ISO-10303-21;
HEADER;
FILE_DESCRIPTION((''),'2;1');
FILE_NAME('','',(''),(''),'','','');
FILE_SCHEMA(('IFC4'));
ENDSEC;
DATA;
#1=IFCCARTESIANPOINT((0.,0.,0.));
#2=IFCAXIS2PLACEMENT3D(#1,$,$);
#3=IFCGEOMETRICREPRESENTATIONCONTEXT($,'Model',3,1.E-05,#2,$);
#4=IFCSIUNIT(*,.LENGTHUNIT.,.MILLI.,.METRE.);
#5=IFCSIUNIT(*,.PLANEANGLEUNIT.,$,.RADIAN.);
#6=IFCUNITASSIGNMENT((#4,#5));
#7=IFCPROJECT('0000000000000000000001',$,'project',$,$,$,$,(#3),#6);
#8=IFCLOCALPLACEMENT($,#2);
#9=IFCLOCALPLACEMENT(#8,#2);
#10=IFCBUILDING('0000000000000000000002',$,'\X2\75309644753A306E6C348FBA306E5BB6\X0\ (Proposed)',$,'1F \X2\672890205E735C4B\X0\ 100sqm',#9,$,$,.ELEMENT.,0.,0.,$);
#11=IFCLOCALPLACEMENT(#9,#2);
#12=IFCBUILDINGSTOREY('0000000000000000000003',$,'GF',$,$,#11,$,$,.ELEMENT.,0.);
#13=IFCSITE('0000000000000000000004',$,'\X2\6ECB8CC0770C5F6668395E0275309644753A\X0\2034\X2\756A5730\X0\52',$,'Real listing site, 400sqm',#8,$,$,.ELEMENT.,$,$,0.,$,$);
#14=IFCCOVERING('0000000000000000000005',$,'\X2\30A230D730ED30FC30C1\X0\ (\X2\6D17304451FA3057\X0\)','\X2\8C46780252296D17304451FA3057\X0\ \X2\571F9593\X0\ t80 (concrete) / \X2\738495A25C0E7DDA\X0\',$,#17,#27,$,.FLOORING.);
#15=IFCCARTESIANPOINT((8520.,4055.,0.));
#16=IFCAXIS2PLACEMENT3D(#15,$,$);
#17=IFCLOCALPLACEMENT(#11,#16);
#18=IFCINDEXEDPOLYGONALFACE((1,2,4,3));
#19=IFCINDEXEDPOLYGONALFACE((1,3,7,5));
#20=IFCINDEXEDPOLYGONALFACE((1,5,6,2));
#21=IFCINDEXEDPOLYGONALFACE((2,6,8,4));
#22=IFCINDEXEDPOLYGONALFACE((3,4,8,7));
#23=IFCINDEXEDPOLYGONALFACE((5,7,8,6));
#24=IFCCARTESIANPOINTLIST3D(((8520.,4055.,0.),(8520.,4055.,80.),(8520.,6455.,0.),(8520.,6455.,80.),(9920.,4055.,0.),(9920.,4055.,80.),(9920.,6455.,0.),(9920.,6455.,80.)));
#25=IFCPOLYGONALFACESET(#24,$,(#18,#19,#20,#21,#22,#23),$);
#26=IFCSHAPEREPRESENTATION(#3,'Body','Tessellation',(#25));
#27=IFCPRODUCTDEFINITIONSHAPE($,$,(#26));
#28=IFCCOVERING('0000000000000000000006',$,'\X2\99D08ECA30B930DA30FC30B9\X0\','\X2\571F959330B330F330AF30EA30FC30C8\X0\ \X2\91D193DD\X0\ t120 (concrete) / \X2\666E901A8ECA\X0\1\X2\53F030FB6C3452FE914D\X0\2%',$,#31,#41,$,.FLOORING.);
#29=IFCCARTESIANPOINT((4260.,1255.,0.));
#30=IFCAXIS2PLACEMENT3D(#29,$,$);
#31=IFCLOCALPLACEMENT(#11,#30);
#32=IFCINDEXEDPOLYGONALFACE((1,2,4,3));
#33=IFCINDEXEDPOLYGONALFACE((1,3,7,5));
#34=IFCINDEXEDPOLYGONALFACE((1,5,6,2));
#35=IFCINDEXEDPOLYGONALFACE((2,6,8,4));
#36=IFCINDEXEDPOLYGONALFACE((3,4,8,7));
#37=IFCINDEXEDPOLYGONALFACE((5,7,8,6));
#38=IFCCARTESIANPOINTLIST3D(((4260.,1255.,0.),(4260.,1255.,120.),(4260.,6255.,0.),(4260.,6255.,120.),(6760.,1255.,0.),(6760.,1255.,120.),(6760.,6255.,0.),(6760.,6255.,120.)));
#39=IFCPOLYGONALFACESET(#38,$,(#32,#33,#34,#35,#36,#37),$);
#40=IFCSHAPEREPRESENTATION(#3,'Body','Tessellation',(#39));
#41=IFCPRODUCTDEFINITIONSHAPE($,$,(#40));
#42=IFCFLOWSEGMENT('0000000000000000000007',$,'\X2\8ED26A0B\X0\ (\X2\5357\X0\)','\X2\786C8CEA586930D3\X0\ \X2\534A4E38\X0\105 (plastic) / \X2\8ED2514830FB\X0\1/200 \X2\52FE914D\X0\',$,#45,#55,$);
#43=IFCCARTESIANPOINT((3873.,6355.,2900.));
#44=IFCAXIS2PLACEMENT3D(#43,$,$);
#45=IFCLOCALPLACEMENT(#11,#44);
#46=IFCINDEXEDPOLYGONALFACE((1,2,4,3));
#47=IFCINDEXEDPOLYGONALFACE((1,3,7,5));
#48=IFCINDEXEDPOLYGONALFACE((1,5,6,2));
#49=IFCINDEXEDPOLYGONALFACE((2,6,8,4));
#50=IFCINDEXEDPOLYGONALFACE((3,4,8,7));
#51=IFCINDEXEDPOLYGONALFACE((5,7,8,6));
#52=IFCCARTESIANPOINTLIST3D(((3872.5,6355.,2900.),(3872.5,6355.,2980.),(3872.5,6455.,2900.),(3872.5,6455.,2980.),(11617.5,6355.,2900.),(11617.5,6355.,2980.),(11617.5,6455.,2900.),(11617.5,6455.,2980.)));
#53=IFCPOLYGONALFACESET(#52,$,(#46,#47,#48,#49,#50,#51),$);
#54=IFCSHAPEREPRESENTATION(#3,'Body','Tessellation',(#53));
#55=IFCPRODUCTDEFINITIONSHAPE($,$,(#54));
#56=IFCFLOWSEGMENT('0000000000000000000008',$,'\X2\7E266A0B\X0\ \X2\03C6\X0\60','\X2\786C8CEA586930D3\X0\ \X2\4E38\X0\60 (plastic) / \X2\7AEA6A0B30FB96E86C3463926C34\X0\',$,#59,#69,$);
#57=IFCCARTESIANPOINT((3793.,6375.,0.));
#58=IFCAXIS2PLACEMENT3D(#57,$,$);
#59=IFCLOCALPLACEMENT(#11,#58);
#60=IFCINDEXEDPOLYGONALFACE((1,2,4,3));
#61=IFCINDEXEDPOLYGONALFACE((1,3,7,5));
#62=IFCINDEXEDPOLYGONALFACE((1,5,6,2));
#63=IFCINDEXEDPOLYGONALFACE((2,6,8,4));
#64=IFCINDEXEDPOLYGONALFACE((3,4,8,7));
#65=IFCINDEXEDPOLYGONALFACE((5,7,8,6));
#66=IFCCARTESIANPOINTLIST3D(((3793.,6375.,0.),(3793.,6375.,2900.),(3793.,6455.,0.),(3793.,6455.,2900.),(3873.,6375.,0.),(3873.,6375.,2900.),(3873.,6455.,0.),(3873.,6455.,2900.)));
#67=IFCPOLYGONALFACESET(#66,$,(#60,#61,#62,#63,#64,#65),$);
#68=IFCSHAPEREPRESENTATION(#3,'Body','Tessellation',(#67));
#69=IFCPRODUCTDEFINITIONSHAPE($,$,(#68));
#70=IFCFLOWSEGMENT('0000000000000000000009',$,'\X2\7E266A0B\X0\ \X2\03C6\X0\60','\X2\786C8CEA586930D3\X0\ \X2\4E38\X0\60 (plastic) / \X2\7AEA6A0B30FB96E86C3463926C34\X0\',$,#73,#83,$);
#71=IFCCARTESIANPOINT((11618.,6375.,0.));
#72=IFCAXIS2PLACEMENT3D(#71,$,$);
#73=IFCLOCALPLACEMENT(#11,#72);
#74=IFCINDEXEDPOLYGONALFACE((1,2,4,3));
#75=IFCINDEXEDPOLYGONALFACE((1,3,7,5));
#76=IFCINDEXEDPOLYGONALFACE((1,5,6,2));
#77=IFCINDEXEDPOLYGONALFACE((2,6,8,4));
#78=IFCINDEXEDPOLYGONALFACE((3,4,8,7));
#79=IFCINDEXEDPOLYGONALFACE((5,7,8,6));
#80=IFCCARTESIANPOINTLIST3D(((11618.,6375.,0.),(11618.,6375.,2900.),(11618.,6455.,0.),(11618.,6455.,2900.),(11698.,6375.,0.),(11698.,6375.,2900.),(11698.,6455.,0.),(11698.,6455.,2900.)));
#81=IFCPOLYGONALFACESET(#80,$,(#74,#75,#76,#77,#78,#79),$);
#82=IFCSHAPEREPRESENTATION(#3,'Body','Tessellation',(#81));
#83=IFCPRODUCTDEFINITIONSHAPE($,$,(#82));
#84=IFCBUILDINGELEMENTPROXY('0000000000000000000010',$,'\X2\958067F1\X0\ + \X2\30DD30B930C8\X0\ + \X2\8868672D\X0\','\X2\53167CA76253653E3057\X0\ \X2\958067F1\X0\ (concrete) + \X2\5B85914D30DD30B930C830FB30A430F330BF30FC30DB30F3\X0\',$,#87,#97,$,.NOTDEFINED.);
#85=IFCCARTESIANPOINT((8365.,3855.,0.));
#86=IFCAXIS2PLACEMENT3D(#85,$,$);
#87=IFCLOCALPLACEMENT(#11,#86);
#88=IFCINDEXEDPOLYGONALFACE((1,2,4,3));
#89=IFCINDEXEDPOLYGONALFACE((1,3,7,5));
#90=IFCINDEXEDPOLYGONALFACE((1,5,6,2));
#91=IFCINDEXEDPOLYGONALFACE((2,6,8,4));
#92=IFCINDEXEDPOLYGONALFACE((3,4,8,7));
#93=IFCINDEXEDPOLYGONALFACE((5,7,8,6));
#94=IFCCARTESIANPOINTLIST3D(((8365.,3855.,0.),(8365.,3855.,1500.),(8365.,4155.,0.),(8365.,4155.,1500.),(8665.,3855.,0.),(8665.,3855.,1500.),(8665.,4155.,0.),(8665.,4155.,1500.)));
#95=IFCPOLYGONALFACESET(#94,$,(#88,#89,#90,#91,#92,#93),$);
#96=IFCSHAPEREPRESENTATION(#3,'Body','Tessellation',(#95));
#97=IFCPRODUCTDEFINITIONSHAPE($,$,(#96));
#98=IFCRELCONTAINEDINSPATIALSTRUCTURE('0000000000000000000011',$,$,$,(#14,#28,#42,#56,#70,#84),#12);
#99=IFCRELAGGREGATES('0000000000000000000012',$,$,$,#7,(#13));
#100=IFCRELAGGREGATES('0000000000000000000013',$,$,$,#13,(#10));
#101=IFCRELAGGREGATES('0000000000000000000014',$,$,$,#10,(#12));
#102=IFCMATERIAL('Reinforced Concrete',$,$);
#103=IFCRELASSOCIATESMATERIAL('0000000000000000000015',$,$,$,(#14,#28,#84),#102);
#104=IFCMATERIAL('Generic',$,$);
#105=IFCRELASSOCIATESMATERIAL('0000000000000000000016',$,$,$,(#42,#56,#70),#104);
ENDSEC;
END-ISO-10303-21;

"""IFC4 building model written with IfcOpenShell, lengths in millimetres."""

from ifc_helpers import new_model, si_unit, frame, frame_2d, origin, place, context, project, spatial, rectangle, extrude, material, element, save


model = new_model("IFC4")

# Units and contexts
model_context = context("Model", 3, precision=1e-05, world=origin())
ifc_project = project(units=[si_unit("LENGTHUNIT", "METRE", prefix="MILLI"), si_unit("PLANEANGLEUNIT", "RADIAN")], contexts=[model_context])

# Site, building, storey
site_placement = place(None, origin())
site = spatial("IfcSite", under=ifc_project, at=site_placement, Name="滋賀県彦根市田附町2034番地52", ObjectType="Real listing site, 400sqm", CompositionType="ELEMENT", RefElevation=0.0)
building_placement = place(site_placement, origin())
building = spatial("IfcBuilding", under=site, at=building_placement, Name="田附町の水辺の家 (Proposed)", ObjectType="1F 木造平屋 100sqm", CompositionType="ELEMENT", ElevationOfRefHeight=0.0, ElevationOfTerrain=0.0)
storey_placement = place(building_placement, origin())
storey = spatial("IfcBuildingStorey", under=building, at=storey_placement, Name="GF", CompositionType="ELEMENT", Elevation=0.0)

# Shared definitions
ifc_material_1 = material(Name="Reinforced Concrete")

# Coverings
ifc_material_2 = material(Name="Generic")
covering_1_placement = place(storey_placement, frame((8520.0, 4055.0, 0.0)))
element("IfcCovering", 1, at=covering_1_placement, inside=storey, material=ifc_material_1, Name="アプローチ (洗い出し)", Description="豆砂利洗い出し 土間 t80 (concrete) / 玄関導線", PredefinedType="FLOORING", context=model_context, shape_type="SweptSolid", body=[
    extrude(rectangle(XDim=1400.0, YDim=2400.0, at=frame_2d((700.0, 1200.0))), frame((8520.0, 4055.0, 0.0)), (0.0, 0.0, 1.0), 80.0),
])
covering_2_placement = place(storey_placement, frame((4260.0, 1255.0, 0.0)))
element("IfcCovering", 2, at=covering_2_placement, inside=storey, material=ifc_material_1, Name="駐車スペース", Description="土間コンクリート 金鏝 t120 (concrete) / 普通車1台・水勾配2%", PredefinedType="FLOORING", context=model_context, shape_type="SweptSolid", body=[
    extrude(rectangle(XDim=2500.0, YDim=5000.0, at=frame_2d((1250.0, 2500.0))), frame((4260.0, 1255.0, 0.0)), (0.0, 0.0, 1.0), 120.0),
])

# Flow segments
flow_segment_1_placement = place(storey_placement, frame((3873.0, 6355.0, 2900.0)))
element("IfcFlowSegment", 3, at=flow_segment_1_placement, inside=storey, material=ifc_material_2, Name="軒樋 (南)", Description="硬質塩ビ 半丸105 (plastic) / 軒先・1/200 勾配", context=model_context, shape_type="SweptSolid", body=[
    extrude(rectangle(XDim=7745.0, YDim=100.0, at=frame_2d((3872.0, 50.0))), frame((3873.0, 6355.0, 2900.0)), (0.0, 0.0, 1.0), 80.0),
])
flow_segment_2_placement = place(storey_placement, frame((3793.0, 6375.0, 0.0)))
element("IfcFlowSegment", 4, at=flow_segment_2_placement, inside=storey, material=ifc_material_2, Name="縦樋 φ60", Description="硬質塩ビ 丸60 (plastic) / 竪樋・雨水排水", context=model_context, shape_type="SweptSolid", body=[
    extrude(rectangle(XDim=80.0, YDim=80.0, at=frame_2d((40.0, 40.0))), frame((3793.0, 6375.0, 0.0)), (0.0, 0.0, 1.0), 2900.0),
])
flow_segment_3_placement = place(storey_placement, frame((11618.0, 6375.0, 0.0)))
element("IfcFlowSegment", 5, at=flow_segment_3_placement, inside=storey, material=ifc_material_2, Name="縦樋 φ60", Description="硬質塩ビ 丸60 (plastic) / 竪樋・雨水排水", context=model_context, shape_type="SweptSolid", body=[
    extrude(rectangle(XDim=80.0, YDim=80.0, at=frame_2d((40.0, 40.0))), frame((11618.0, 6375.0, 0.0)), (0.0, 0.0, 1.0), 2900.0),
])

# Building element proxy
proxy_placement = place(storey_placement, frame((8365.0, 3855.0, 0.0)))
element("IfcBuildingElementProxy", 6, at=proxy_placement, inside=storey, material=ifc_material_1, Name="門柱 + ポスト + 表札", Description="化粧打放し 門柱 (concrete) + 宅配ポスト・インターホン", PredefinedType="NOTDEFINED", context=model_context, shape_type="SweptSolid", body=[
    extrude(rectangle(XDim=300.0, YDim=300.0, at=frame_2d((150.0, 150.0))), frame((8365.0, 3855.0, 0.0)), (0.0, 0.0, 1.0), 1500.0),
])

save(model, "model.ifc")
